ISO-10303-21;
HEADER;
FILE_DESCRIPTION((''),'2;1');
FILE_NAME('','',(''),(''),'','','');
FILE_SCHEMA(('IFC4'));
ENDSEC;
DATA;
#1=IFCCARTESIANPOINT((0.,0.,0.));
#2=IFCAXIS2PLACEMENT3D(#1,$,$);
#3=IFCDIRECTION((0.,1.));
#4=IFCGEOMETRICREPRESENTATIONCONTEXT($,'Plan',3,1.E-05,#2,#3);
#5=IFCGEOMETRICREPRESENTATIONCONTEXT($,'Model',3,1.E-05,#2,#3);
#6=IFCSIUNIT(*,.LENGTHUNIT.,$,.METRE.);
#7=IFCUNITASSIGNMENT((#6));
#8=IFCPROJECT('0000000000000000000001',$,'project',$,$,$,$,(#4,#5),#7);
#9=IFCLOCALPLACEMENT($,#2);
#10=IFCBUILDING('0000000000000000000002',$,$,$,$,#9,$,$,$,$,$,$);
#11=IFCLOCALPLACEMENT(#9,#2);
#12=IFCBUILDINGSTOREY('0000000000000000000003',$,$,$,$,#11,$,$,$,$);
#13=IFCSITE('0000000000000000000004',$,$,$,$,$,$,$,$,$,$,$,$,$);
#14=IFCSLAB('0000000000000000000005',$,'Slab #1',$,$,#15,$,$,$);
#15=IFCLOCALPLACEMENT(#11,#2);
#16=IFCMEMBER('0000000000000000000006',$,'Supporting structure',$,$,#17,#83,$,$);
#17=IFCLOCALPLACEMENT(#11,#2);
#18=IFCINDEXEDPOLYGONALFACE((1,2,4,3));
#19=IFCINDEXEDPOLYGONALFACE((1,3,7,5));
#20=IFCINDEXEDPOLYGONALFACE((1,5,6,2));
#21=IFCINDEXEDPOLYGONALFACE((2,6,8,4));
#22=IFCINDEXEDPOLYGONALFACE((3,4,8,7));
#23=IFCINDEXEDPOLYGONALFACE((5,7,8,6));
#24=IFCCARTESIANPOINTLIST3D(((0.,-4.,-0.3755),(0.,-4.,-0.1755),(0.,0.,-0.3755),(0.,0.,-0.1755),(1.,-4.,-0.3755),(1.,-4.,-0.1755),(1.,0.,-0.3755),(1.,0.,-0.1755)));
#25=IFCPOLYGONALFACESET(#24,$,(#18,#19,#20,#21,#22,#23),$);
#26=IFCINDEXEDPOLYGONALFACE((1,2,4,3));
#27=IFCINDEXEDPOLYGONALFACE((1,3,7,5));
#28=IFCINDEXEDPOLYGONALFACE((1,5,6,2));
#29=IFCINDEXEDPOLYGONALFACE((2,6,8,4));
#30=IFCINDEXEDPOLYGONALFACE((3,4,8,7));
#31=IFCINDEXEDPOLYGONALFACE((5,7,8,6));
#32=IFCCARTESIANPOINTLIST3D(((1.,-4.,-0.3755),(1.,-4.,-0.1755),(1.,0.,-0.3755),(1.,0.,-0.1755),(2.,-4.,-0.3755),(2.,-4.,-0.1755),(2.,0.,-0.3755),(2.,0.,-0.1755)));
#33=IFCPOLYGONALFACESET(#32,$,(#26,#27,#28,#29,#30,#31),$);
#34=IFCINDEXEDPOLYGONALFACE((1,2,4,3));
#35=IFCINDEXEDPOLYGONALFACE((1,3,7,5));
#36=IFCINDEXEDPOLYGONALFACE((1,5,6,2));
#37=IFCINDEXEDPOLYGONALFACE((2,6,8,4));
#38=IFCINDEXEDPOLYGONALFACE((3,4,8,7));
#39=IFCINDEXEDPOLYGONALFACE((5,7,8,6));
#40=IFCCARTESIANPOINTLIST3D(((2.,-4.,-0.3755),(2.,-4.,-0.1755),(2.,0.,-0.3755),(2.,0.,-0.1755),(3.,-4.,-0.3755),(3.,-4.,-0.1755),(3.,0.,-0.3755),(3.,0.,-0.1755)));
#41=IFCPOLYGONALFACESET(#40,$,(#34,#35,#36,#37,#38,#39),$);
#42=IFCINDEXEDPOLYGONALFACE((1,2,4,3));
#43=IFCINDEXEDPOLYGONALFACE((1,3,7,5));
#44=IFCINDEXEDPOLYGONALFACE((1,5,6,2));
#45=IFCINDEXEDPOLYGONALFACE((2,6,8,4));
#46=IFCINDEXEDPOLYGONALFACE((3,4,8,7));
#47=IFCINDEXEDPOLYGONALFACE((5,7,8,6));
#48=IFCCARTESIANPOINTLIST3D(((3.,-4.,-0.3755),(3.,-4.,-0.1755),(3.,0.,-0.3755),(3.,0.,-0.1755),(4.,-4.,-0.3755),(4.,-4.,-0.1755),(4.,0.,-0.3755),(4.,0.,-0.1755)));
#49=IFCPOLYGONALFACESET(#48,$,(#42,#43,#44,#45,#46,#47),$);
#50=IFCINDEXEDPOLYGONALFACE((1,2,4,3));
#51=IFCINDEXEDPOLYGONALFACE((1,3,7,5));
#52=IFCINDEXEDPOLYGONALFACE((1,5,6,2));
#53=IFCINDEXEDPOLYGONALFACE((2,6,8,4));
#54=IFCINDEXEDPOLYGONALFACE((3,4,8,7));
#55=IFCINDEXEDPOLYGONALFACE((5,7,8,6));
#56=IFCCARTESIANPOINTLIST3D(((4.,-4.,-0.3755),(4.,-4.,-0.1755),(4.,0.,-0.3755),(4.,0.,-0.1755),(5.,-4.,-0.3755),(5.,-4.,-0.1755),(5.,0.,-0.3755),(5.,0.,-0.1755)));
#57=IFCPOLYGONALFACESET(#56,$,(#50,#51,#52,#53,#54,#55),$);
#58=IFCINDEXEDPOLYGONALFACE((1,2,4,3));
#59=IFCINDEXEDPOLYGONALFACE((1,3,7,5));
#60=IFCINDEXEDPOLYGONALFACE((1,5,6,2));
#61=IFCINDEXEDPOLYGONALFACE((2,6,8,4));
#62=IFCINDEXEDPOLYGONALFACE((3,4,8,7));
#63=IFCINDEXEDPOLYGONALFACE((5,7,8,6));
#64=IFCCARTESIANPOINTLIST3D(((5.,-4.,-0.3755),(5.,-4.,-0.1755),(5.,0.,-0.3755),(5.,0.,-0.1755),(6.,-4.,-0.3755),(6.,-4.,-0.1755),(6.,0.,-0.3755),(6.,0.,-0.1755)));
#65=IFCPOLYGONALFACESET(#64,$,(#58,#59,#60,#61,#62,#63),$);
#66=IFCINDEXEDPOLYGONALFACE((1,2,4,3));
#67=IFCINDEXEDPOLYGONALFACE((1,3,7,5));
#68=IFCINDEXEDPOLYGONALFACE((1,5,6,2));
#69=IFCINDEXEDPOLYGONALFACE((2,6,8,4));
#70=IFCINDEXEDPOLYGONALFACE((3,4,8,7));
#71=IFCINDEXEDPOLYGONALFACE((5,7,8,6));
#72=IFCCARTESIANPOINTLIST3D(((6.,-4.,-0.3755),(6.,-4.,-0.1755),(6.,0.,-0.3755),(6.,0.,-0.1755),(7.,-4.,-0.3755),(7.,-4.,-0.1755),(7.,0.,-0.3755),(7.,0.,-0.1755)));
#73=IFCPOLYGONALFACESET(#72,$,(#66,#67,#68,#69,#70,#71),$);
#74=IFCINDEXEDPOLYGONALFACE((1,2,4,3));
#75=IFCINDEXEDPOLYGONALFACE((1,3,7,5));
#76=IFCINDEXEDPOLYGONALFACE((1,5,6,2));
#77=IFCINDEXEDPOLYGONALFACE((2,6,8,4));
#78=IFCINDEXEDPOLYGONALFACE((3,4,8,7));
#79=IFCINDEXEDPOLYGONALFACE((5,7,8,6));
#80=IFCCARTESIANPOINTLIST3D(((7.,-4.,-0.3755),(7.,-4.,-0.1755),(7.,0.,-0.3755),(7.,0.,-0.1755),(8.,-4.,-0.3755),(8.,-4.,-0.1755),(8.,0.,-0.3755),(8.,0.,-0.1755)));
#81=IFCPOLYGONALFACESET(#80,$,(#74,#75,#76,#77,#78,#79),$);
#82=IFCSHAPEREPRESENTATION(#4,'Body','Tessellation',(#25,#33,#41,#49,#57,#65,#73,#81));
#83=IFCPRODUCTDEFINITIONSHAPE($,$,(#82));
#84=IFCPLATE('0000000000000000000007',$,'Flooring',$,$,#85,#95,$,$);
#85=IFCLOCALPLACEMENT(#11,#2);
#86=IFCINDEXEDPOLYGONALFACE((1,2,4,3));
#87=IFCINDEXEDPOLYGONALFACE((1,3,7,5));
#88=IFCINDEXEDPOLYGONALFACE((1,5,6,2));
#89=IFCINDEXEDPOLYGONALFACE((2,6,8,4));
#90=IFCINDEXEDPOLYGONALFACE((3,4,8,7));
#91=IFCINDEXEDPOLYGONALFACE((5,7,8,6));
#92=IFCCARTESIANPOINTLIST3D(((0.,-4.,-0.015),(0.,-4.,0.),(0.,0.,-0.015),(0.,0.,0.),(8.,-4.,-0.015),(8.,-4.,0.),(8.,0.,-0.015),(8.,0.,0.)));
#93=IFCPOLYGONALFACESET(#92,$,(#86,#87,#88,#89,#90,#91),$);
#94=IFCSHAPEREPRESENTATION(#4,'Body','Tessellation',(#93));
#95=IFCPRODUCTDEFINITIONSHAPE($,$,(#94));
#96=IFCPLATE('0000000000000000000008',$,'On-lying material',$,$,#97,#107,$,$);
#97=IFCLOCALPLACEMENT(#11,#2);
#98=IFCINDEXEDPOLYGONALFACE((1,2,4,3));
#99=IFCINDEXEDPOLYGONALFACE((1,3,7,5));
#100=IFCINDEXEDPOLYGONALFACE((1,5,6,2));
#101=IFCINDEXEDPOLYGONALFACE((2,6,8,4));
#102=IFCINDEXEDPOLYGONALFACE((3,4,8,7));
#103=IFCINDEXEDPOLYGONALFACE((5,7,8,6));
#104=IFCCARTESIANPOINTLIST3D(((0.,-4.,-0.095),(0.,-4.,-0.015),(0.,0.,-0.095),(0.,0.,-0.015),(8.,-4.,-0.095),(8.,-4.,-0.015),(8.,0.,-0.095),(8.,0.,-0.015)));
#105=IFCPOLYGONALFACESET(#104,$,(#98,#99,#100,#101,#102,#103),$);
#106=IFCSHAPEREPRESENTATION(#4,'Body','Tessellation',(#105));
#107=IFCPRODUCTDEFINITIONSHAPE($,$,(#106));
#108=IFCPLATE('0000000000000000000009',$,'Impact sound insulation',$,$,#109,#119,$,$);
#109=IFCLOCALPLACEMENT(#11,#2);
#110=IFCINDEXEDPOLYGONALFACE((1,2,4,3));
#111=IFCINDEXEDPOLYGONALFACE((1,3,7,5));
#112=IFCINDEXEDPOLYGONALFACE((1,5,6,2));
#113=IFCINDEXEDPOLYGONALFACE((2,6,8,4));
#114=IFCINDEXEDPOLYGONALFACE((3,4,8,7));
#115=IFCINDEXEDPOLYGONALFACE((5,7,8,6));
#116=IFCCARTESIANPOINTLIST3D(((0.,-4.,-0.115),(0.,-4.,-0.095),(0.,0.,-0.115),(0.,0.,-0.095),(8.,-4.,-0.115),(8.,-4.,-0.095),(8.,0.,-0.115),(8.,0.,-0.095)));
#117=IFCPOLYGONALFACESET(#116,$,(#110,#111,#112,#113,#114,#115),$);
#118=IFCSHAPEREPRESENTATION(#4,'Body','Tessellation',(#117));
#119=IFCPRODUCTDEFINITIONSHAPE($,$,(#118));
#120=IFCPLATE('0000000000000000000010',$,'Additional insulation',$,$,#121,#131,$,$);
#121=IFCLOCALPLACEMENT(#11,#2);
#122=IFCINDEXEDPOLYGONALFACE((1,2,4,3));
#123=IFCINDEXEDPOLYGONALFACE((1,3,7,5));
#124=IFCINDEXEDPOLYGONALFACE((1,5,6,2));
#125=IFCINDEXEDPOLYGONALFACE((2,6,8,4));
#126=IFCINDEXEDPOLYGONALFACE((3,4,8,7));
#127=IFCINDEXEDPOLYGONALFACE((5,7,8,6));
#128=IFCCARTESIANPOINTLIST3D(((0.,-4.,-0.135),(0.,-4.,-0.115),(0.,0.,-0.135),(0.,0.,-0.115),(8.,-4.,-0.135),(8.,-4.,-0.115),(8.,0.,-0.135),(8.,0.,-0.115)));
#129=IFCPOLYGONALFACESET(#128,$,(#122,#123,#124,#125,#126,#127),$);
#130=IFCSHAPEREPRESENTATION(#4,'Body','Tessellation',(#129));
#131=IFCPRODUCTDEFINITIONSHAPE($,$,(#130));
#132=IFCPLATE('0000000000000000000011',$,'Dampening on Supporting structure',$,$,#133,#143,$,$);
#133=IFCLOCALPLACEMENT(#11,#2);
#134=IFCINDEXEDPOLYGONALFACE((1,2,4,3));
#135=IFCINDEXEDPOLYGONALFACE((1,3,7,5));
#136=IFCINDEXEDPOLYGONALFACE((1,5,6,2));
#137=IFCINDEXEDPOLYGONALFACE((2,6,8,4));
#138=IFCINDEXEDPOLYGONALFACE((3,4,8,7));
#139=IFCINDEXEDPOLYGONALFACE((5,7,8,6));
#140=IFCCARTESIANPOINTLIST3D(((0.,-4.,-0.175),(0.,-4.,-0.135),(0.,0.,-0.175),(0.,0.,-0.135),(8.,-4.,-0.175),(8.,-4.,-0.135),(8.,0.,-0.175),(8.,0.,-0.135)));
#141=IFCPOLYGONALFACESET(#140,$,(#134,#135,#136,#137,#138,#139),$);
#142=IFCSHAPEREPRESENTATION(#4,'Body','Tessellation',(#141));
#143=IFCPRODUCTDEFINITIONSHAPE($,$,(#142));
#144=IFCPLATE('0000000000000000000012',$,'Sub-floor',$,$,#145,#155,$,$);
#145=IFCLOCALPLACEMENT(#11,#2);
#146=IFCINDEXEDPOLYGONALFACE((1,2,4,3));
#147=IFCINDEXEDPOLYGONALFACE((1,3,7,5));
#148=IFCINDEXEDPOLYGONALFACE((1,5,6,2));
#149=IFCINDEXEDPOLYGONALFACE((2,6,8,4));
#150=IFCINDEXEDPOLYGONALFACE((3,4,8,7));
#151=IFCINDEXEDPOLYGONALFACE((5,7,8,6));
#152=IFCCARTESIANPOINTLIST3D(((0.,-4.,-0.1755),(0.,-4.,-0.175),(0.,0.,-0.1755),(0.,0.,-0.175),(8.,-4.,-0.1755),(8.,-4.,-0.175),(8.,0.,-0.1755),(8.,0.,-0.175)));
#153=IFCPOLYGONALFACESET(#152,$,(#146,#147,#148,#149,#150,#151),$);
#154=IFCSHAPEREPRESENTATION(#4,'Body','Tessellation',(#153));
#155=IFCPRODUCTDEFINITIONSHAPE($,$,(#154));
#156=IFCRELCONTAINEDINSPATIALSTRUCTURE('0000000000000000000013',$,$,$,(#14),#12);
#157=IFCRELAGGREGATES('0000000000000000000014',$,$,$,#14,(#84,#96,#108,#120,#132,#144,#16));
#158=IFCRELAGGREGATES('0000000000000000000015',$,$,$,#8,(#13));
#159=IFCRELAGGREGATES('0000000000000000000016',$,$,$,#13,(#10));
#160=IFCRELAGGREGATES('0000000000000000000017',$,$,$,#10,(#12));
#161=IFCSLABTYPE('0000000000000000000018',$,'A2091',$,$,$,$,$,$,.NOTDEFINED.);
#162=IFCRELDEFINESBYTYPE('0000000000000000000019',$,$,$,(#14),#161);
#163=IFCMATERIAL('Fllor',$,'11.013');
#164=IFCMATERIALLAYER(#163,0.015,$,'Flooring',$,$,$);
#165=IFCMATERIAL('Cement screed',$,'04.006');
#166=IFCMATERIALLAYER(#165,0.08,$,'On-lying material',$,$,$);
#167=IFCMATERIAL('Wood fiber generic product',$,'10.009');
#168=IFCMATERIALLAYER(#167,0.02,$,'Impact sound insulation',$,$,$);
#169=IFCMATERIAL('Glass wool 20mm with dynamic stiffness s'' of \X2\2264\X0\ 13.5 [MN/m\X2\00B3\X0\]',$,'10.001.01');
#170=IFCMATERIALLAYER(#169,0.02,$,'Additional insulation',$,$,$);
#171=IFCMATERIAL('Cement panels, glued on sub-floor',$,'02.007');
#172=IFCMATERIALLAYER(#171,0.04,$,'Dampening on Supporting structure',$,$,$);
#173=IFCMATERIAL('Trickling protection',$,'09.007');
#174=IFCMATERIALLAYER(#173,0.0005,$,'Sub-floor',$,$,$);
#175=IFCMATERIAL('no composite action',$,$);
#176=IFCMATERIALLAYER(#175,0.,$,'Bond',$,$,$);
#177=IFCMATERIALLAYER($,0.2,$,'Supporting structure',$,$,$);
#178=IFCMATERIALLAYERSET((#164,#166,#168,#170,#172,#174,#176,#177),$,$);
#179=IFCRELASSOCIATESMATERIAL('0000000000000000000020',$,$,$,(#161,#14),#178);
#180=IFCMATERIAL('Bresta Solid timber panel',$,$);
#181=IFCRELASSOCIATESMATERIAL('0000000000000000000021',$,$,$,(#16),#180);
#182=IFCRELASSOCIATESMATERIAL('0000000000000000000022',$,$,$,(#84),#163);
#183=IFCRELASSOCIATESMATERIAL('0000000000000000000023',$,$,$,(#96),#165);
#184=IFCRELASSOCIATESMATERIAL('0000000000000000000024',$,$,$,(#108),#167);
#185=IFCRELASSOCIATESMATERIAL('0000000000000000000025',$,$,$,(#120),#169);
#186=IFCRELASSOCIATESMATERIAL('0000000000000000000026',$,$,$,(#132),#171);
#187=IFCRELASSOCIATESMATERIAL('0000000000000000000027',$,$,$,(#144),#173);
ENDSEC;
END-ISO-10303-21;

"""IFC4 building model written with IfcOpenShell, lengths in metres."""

from ifc_helpers import new_model, si_unit, direction, frame, frame_2d, origin, origin_with_axes, place, context, project, spatial, rectangle, extrude, material, layer, layer_set, type_object, element, aggregate, save


model = new_model("IFC4")

# Units and contexts
plan_context = context("Plan", 3, precision=1e-05, world=origin(), true_north=direction((0.0, 1.0)))
model_context = context("Model", 3, precision=1e-05, world=origin(), true_north=direction((0.0, 1.0)))
ifc_project = project(units=[si_unit("LENGTHUNIT", "METRE")], contexts=[plan_context, model_context])

# Site, building, storey
site = spatial("IfcSite", under=ifc_project)
building_placement = place(None, origin())
building = spatial("IfcBuilding", under=site, at=building_placement)
storey_placement = place(building_placement, origin())
storey = spatial("IfcBuildingStorey", under=building, at=storey_placement)

# Slab, member, plates
ifc_material_1 = material(Name="Fllor", Category="11.013")
ifc_layer_1 = layer(ifc_material_1, 0.015, Name="Flooring")
ifc_material_2 = material(Name="Cement screed", Category="04.006")
ifc_layer_2 = layer(ifc_material_2, 0.08, Name="On-lying material")
ifc_material_3 = material(Name="Wood fiber generic product", Category="10.009")
ifc_layer_3 = layer(ifc_material_3, 0.02, Name="Impact sound insulation")
ifc_material_4 = material(Name="Glass wool 20mm with dynamic stiffness s' of ≤ 13.5 [MN/m³]", Category="10.001.01")
ifc_layer_4 = layer(ifc_material_4, 0.02, Name="Additional insulation")
ifc_material_5 = material(Name="Cement panels, glued on sub-floor", Category="02.007")
ifc_layer_5 = layer(ifc_material_5, 0.04, Name="Dampening on Supporting structure")
ifc_material_6 = material(Name="Trickling protection", Category="09.007")
ifc_layer_6 = layer(ifc_material_6, 0.0005, Name="Sub-floor")
ifc_material_7 = material(Name="no composite action")
ifc_layer_7 = layer(ifc_material_7, 0.0, Name="Bond")
ifc_layer_8 = layer(None, 0.2, Name="Supporting structure")
ifc_layer_set = layer_set([ifc_layer_1, ifc_layer_2, ifc_layer_3, ifc_layer_4, ifc_layer_5, ifc_layer_6, ifc_layer_7, ifc_layer_8])
slab_type = type_object("IfcSlabType", Name="A2091", PredefinedType="NOTDEFINED", material=ifc_layer_set)
slab_placement = place(None, frame((0.0, 0.0, 0.0), z_axis=(0.0, 0.0, -1.0), x_axis=(1.0, 0.0, 0.0)))
slab = element("IfcSlab", 1, at=slab_placement, inside=storey, type_object=slab_type, material=ifc_layer_set, Name="Slab #1")
ifc_material_8 = material(Name="Bresta Solid timber panel")
member_placement = place(slab_placement, origin())
member = element("IfcMember", 2, at=member_placement, material=ifc_material_8, Name="Supporting structure", context=plan_context, shape_type="SweptSolid", body=[
    extrude(rectangle(XDim=1.0, YDim=0.2, at=frame_2d((0.5, 0.1), x_axis=(1.0, 0.0))), frame((0.0, 4.0, 0.1755), z_axis=(0.0, -1.0, 0.0), x_axis=(1.0, 0.0, 0.0)), (0.0, 0.0, 1.0), 4.0),
    extrude(rectangle(XDim=1.0, YDim=0.2, at=frame_2d((0.5, 0.1), x_axis=(1.0, 0.0))), frame((1.0, 4.0, 0.1755), z_axis=(0.0, -1.0, 0.0), x_axis=(1.0, 0.0, 0.0)), (0.0, 0.0, 1.0), 4.0),
    extrude(rectangle(XDim=1.0, YDim=0.2, at=frame_2d((0.5, 0.1), x_axis=(1.0, 0.0))), frame((2.0, 4.0, 0.1755), z_axis=(0.0, -1.0, 0.0), x_axis=(1.0, 0.0, 0.0)), (0.0, 0.0, 1.0), 4.0),
    extrude(rectangle(XDim=1.0, YDim=0.2, at=frame_2d((0.5, 0.1), x_axis=(1.0, 0.0))), frame((3.0, 4.0, 0.1755), z_axis=(0.0, -1.0, 0.0), x_axis=(1.0, 0.0, 0.0)), (0.0, 0.0, 1.0), 4.0),
    extrude(rectangle(XDim=1.0, YDim=0.2, at=frame_2d((0.5, 0.1), x_axis=(1.0, 0.0))), frame((4.0, 4.0, 0.1755), z_axis=(0.0, -1.0, 0.0), x_axis=(1.0, 0.0, 0.0)), (0.0, 0.0, 1.0), 4.0),
    extrude(rectangle(XDim=1.0, YDim=0.2, at=frame_2d((0.5, 0.1), x_axis=(1.0, 0.0))), frame((5.0, 4.0, 0.1755), z_axis=(0.0, -1.0, 0.0), x_axis=(1.0, 0.0, 0.0)), (0.0, 0.0, 1.0), 4.0),
    extrude(rectangle(XDim=1.0, YDim=0.2, at=frame_2d((0.5, 0.1), x_axis=(1.0, 0.0))), frame((6.0, 4.0, 0.1755), z_axis=(0.0, -1.0, 0.0), x_axis=(1.0, 0.0, 0.0)), (0.0, 0.0, 1.0), 4.0),
    extrude(rectangle(XDim=1.0, YDim=0.2, at=frame_2d((0.5, 0.1), x_axis=(1.0, 0.0))), frame((7.0, 4.0, 0.1755), z_axis=(0.0, -1.0, 0.0), x_axis=(1.0, 0.0, 0.0)), (0.0, 0.0, 1.0), 4.0),
])
plate_1_placement = place(slab_placement, origin())
plate_1 = element("IfcPlate", 3, at=plate_1_placement, material=ifc_material_1, Name="Flooring", context=plan_context, shape_type="SweptSolid", body=[
    extrude(rectangle(XDim=8.0, YDim=4.0, at=frame_2d((4.0, 2.0), x_axis=(1.0, 0.0))), origin_with_axes(), (0.0, 0.0, 1.0), 0.015),
])
plate_2_placement = place(slab_placement, origin())
plate_2 = element("IfcPlate", 4, at=plate_2_placement, material=ifc_material_2, Name="On-lying material", context=plan_context, shape_type="SweptSolid", body=[
    extrude(rectangle(XDim=8.0, YDim=4.0, at=frame_2d((4.0, 2.0), x_axis=(1.0, 0.0))), frame((0.0, 0.0, 0.015), z_axis=(0.0, 0.0, 1.0), x_axis=(1.0, 0.0, 0.0)), (0.0, 0.0, 1.0), 0.08),
])
plate_3_placement = place(slab_placement, origin())
plate_3 = element("IfcPlate", 5, at=plate_3_placement, material=ifc_material_3, Name="Impact sound insulation", context=plan_context, shape_type="SweptSolid", body=[
    extrude(rectangle(XDim=8.0, YDim=4.0, at=frame_2d((4.0, 2.0), x_axis=(1.0, 0.0))), frame((0.0, 0.0, 0.095), z_axis=(0.0, 0.0, 1.0), x_axis=(1.0, 0.0, 0.0)), (0.0, 0.0, 1.0), 0.02),
])
plate_4_placement = place(slab_placement, origin())
plate_4 = element("IfcPlate", 6, at=plate_4_placement, material=ifc_material_4, Name="Additional insulation", context=plan_context, shape_type="SweptSolid", body=[
    extrude(rectangle(XDim=8.0, YDim=4.0, at=frame_2d((4.0, 2.0), x_axis=(1.0, 0.0))), frame((0.0, 0.0, 0.115), z_axis=(0.0, 0.0, 1.0), x_axis=(1.0, 0.0, 0.0)), (0.0, 0.0, 1.0), 0.02),
])
plate_5_placement = place(slab_placement, origin())
plate_5 = element("IfcPlate", 7, at=plate_5_placement, material=ifc_material_5, Name="Dampening on Supporting structure", context=plan_context, shape_type="SweptSolid", body=[
    extrude(rectangle(XDim=8.0, YDim=4.0, at=frame_2d((4.0, 2.0), x_axis=(1.0, 0.0))), frame((0.0, 0.0, 0.135), z_axis=(0.0, 0.0, 1.0), x_axis=(1.0, 0.0, 0.0)), (0.0, 0.0, 1.0), 0.04),
])
plate_6_placement = place(slab_placement, origin())
plate_6 = element("IfcPlate", 8, at=plate_6_placement, material=ifc_material_6, Name="Sub-floor", context=plan_context, shape_type="SweptSolid", body=[
    extrude(rectangle(XDim=8.0, YDim=4.0, at=frame_2d((4.0, 2.0), x_axis=(1.0, 0.0))), frame((0.0, 0.0, 0.175), z_axis=(0.0, 0.0, 1.0), x_axis=(1.0, 0.0, 0.0)), (0.0, 0.0, 1.0), 0.0005),
])
aggregate(slab, [plate_1, plate_2, plate_3, plate_4, plate_5, plate_6, member])

save(model, "model.ifc")
